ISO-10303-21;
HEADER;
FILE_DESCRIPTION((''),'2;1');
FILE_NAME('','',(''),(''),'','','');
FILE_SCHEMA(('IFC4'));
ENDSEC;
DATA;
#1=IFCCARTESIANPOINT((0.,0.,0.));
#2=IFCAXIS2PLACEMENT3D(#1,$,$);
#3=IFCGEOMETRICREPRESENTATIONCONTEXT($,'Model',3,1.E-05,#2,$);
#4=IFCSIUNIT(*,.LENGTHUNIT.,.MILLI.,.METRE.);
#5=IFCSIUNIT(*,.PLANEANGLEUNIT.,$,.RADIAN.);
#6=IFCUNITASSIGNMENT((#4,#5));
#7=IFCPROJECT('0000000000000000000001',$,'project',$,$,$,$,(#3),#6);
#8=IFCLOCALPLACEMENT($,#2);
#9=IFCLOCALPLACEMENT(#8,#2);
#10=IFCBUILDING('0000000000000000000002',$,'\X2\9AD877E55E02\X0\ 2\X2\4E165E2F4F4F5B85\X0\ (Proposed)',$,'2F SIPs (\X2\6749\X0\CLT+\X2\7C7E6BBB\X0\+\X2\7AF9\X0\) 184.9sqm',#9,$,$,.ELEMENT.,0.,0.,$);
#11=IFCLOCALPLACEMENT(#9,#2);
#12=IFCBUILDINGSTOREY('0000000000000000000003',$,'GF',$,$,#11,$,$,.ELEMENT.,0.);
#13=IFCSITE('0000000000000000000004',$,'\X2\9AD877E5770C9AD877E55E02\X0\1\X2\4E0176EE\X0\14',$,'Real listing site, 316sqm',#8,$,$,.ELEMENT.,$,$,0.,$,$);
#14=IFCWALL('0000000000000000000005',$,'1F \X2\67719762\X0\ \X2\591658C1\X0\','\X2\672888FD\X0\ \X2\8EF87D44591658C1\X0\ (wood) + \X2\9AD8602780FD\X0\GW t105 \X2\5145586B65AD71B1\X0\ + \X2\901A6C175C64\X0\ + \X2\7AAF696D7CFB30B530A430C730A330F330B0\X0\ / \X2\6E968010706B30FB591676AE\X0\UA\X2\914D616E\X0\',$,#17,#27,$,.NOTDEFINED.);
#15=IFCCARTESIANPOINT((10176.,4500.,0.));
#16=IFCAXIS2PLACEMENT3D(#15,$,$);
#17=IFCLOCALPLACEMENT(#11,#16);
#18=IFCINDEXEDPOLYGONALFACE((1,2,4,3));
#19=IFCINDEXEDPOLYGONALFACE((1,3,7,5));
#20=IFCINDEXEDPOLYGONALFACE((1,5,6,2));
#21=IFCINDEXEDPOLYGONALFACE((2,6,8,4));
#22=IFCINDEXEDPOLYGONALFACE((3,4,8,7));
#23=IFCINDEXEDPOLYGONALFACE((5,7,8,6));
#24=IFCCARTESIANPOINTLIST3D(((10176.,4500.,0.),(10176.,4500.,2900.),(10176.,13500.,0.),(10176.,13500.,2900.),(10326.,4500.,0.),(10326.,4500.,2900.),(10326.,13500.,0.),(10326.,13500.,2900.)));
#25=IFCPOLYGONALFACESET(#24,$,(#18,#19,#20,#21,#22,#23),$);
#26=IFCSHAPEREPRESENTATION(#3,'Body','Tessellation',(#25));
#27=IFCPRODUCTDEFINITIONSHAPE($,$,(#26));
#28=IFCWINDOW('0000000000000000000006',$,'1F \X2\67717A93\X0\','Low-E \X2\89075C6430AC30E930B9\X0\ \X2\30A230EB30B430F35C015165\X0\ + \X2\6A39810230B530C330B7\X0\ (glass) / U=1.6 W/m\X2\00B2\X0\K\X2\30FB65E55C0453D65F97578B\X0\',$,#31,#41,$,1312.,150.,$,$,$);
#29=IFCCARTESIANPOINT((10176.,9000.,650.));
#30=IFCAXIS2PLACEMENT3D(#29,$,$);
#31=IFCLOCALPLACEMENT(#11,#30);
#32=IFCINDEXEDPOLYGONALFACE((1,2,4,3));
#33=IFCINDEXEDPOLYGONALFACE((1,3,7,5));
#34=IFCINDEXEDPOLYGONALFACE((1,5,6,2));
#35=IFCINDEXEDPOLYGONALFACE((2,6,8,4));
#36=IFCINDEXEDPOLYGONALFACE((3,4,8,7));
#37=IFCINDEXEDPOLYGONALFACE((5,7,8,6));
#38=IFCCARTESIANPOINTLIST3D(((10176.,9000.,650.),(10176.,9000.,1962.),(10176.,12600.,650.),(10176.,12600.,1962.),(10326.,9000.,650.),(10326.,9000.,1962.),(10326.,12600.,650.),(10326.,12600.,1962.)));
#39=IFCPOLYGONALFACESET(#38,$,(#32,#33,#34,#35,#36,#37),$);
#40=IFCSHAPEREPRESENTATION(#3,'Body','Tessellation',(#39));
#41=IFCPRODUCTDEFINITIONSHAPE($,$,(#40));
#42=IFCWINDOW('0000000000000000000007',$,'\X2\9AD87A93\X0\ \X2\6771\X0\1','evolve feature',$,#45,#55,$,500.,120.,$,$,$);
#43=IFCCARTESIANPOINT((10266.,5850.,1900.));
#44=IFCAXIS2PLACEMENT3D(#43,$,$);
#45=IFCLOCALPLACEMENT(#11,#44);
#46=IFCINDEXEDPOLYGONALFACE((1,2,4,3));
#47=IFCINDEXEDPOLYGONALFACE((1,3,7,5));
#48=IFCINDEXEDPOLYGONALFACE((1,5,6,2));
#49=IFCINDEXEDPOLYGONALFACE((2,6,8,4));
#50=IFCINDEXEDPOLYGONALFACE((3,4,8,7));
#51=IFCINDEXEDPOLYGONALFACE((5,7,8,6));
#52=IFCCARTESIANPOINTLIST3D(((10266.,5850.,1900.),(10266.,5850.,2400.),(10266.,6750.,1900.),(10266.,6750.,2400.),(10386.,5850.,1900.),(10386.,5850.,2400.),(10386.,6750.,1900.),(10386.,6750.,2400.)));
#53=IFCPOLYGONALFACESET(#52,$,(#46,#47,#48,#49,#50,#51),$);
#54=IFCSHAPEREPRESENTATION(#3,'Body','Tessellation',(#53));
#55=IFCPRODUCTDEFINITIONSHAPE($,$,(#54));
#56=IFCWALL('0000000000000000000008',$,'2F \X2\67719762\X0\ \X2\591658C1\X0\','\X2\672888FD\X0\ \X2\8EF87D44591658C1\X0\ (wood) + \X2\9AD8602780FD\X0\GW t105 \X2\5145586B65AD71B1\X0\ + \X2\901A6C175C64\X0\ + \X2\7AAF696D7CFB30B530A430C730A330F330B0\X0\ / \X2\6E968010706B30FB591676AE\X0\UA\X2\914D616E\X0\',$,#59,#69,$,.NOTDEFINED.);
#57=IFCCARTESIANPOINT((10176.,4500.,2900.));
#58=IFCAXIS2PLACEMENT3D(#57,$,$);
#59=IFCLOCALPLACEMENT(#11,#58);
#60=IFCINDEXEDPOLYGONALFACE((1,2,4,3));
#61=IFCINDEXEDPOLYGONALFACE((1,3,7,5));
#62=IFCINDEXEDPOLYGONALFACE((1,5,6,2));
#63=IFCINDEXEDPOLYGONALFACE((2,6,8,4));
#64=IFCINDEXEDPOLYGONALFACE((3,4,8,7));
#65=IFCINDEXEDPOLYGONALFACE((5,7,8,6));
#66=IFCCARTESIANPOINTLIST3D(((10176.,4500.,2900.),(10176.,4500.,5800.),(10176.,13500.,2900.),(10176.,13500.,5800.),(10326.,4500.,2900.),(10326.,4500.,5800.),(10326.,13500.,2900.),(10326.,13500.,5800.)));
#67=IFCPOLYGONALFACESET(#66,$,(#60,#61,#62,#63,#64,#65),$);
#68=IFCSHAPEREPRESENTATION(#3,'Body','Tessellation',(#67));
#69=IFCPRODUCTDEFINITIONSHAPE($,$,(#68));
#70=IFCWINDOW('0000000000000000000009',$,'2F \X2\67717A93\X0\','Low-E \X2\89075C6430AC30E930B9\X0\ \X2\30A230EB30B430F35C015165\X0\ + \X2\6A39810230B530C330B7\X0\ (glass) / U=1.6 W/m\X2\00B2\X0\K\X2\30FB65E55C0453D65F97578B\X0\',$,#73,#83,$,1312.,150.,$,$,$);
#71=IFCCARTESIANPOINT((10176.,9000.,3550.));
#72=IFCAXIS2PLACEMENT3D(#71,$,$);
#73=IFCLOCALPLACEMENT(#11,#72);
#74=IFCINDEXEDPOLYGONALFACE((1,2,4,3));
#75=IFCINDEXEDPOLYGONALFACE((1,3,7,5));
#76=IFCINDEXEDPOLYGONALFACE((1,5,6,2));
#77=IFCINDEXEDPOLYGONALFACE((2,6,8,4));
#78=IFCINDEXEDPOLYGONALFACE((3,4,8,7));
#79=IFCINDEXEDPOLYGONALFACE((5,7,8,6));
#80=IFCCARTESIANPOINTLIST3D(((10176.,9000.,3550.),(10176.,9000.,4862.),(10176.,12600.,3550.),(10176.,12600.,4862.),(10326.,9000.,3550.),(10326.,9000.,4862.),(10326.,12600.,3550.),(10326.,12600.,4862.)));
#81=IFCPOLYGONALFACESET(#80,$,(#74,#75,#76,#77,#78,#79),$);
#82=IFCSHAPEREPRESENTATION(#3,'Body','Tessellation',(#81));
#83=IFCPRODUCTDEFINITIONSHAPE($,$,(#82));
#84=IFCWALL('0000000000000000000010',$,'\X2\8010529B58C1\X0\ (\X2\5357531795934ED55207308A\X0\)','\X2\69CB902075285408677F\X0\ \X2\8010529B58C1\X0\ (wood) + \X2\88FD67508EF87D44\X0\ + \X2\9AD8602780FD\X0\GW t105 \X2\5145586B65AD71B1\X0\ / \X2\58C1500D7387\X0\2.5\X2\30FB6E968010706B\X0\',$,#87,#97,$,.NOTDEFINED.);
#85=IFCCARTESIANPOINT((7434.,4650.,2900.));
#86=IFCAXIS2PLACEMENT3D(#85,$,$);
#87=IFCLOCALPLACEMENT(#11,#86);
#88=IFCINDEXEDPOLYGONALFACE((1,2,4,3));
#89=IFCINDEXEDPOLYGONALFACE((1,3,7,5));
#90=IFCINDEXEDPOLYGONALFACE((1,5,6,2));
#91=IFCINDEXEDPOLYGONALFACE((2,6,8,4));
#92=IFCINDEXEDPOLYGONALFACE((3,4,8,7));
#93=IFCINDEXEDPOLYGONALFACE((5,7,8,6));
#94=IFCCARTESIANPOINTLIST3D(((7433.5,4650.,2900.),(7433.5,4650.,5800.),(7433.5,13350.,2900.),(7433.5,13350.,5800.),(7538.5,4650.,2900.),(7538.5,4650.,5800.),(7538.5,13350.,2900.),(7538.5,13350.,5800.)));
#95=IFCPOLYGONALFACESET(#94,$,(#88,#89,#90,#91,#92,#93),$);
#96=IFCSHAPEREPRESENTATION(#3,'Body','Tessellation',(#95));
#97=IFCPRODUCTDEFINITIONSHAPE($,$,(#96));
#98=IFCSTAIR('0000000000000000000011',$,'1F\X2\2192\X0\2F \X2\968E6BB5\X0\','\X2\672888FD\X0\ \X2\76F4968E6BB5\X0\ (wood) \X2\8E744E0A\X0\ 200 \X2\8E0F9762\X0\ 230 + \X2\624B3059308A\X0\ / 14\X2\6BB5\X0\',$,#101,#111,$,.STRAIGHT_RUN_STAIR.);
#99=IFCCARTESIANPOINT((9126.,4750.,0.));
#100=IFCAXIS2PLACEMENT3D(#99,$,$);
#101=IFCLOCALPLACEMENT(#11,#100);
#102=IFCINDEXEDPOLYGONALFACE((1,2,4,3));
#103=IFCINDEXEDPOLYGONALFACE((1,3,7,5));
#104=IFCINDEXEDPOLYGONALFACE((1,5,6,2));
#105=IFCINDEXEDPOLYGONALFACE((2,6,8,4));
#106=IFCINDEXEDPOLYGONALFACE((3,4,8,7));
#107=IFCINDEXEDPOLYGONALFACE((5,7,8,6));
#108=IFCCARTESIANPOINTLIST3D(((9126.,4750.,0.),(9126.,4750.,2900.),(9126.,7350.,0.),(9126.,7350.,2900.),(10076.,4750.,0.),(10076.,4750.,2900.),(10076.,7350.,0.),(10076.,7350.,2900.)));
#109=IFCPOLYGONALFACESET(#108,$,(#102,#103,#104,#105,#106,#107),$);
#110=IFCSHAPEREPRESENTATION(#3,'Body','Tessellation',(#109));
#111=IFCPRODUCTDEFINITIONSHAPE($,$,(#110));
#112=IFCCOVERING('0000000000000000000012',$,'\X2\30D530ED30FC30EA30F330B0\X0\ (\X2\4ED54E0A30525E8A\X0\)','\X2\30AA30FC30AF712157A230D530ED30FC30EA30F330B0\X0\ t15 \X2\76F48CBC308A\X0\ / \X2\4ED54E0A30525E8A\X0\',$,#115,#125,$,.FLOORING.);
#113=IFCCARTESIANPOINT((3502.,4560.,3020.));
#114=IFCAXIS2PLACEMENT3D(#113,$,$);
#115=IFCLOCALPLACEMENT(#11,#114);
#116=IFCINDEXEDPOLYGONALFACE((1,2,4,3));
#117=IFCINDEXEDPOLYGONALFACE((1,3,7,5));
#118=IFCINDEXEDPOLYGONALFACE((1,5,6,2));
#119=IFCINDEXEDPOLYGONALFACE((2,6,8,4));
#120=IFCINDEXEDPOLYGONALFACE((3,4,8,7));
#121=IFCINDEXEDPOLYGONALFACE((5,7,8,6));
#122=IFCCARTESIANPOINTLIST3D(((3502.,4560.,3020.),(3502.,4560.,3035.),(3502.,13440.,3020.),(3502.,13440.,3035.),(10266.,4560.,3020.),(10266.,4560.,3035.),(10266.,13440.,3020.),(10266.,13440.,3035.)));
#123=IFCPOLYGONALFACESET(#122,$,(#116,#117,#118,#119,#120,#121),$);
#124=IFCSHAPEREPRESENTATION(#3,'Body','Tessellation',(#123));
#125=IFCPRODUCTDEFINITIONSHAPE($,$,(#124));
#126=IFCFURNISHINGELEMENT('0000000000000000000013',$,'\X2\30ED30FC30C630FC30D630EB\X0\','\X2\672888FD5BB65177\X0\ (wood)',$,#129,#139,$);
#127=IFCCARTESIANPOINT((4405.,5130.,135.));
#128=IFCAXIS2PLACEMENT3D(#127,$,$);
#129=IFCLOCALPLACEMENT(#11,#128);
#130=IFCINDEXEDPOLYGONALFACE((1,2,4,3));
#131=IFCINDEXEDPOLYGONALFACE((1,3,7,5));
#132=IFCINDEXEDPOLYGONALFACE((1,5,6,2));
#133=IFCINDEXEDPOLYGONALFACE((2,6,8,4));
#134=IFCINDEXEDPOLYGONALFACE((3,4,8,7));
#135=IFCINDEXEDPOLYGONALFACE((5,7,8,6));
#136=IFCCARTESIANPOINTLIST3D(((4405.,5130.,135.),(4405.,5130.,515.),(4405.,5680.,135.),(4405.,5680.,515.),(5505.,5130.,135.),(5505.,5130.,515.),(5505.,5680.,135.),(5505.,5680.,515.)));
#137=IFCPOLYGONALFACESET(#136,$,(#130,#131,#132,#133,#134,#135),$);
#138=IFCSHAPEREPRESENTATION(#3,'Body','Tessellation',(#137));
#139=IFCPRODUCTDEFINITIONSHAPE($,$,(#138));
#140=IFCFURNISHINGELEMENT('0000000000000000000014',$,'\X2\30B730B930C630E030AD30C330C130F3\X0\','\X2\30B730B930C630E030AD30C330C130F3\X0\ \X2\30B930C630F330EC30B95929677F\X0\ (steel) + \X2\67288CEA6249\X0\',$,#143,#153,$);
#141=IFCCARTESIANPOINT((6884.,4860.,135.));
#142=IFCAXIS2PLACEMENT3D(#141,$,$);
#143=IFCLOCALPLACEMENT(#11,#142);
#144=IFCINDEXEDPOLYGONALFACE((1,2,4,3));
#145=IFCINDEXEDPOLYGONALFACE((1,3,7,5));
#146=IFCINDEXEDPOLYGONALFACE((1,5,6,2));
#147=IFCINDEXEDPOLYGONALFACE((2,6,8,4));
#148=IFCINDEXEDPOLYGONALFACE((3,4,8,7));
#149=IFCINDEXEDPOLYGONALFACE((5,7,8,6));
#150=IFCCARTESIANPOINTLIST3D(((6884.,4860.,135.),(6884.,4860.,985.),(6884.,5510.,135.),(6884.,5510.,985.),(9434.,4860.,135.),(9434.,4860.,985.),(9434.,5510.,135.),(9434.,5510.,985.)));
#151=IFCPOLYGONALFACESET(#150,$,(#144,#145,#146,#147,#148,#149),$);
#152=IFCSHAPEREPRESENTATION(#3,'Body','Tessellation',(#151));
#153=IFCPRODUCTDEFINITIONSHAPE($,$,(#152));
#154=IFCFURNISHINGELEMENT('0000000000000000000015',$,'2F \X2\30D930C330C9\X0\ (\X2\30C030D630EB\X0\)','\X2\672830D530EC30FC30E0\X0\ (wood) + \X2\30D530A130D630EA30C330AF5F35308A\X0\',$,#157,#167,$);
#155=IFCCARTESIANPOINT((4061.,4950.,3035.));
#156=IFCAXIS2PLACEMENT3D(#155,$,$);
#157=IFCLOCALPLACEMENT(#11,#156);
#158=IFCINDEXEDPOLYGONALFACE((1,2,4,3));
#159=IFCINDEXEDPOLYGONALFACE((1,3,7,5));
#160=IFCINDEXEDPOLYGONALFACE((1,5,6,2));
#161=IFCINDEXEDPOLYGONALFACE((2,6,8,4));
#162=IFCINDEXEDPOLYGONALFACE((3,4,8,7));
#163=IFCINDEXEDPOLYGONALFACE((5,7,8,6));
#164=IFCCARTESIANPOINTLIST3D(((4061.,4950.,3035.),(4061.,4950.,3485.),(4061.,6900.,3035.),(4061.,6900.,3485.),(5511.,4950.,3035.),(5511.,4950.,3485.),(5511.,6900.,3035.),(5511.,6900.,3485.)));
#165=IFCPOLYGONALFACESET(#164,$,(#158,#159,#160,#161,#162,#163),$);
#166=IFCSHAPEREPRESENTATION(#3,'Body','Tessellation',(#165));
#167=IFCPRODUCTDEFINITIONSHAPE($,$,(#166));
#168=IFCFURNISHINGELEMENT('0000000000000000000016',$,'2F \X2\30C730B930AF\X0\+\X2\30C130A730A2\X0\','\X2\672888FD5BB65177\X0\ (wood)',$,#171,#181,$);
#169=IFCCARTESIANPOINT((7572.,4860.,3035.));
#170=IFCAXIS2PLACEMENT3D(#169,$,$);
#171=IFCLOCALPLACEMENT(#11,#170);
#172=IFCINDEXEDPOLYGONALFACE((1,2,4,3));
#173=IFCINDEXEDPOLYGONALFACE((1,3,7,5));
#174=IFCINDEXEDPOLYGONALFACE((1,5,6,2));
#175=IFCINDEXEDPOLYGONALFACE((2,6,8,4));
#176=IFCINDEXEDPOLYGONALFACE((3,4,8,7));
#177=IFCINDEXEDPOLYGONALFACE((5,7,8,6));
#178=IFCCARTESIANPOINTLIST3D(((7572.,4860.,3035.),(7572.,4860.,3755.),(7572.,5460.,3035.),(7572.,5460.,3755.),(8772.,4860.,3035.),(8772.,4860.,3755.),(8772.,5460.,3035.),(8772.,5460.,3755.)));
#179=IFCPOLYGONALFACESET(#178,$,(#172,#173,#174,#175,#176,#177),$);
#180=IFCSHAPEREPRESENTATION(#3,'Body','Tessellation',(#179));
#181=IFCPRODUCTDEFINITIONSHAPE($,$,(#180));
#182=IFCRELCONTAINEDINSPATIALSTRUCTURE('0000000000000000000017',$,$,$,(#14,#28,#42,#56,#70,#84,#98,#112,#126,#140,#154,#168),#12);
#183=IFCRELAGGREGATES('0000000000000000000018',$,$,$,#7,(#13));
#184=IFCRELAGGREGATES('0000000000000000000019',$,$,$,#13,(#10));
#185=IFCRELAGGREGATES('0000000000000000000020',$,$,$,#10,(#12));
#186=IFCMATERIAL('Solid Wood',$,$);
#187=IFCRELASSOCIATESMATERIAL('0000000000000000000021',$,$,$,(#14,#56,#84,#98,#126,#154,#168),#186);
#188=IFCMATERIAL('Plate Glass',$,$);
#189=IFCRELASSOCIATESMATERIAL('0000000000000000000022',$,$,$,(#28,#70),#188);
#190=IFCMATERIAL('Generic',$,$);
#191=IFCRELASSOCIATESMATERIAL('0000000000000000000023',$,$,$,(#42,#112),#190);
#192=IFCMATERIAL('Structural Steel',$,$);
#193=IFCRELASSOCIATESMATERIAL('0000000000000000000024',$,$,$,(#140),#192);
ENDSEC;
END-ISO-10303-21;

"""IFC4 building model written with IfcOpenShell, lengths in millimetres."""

from ifc_helpers import new_model, si_unit, frame, frame_2d, origin, place, context, project, spatial, rectangle, extrude, material, element, fill, save


model = new_model("IFC4")

# Units and contexts
model_context = context("Model", 3, precision=1e-05, world=origin())
ifc_project = project(units=[si_unit("LENGTHUNIT", "METRE", prefix="MILLI"), si_unit("PLANEANGLEUNIT", "RADIAN")], contexts=[model_context])

# Site, building, storey
site_placement = place(None, origin())
site = spatial("IfcSite", under=ifc_project, at=site_placement, Name="高知県高知市1丁目14", ObjectType="Real listing site, 316sqm", CompositionType="ELEMENT", RefElevation=0.0)
building_placement = place(site_placement, origin())
building = spatial("IfcBuilding", under=site, at=building_placement, Name="高知市 2世帯住宅 (Proposed)", ObjectType="2F SIPs (杉CLT+籾殻+竹) 184.9sqm", CompositionType="ELEMENT", ElevationOfRefHeight=0.0, ElevationOfTerrain=0.0)
storey_placement = place(building_placement, origin())
storey = spatial("IfcBuildingStorey", under=building, at=storey_placement, Name="GF", CompositionType="ELEMENT", Elevation=0.0)

# Shared definitions
ifc_material_1 = material(Name="Solid Wood")

# Wall, openings, windows
wall_1_placement = place(storey_placement, frame((10176.0, 4500.0, 0.0)))
wall_1 = element("IfcWall", 1, at=wall_1_placement, inside=storey, material=ifc_material_1, Name="1F 東面 外壁", Description="木製 軸組外壁 (wood) + 高性能GW t105 充填断熱 + 通気層 + 窯業系サイディング / 準耐火・外皮UA配慮", PredefinedType="NOTDEFINED", context=model_context, shape_type="SweptSolid", body=[
    extrude(rectangle(XDim=150.0, YDim=9000.0, at=frame_2d((75.0, 4500.0))), frame((10176.0, 4500.0, 0.0)), (0.0, 0.0, 1.0), 2900.0),
])
opening_1_placement = place(storey_placement, frame((10176.0, 9000.0, 650.0)))
opening_1 = element("IfcOpeningElement", 2, at=opening_1_placement, cuts=wall_1, PredefinedType="NOTDEFINED", context=model_context, shape_type="SweptSolid", body=[
    extrude(rectangle(XDim=150.0, YDim=3600.0, at=frame_2d((75.0, 1800.0))), frame((10176.0, 9000.0, 650.0)), (0.0, 0.0, 1.0), 1312.0),
])
opening_2_placement = place(storey_placement, frame((10266.0, 5850.0, 1900.0)))
opening_2 = element("IfcOpeningElement", 3, at=opening_2_placement, cuts=wall_1, PredefinedType="NOTDEFINED", context=model_context, shape_type="SweptSolid", body=[
    extrude(rectangle(XDim=120.0, YDim=900.0, at=frame_2d((60.0, 450.0))), frame((10266.0, 5850.0, 1900.0)), (0.0, 0.0, 1.0), 500.0),
])
ifc_material_2 = material(Name="Plate Glass")
window_1_placement = place(storey_placement, frame((10176.0, 9000.0, 650.0)))
window_1 = element("IfcWindow", 4, at=window_1_placement, inside=storey, material=ifc_material_2, Name="1F 東窓", Description="Low-E 複層ガラス アルゴン封入 + 樹脂サッシ (glass) / U=1.6 W/m²K・日射取得型", OverallHeight=1312.0, OverallWidth=150.0, context=model_context, shape_type="SweptSolid", body=[
    extrude(rectangle(XDim=150.0, YDim=3600.0, at=frame_2d((75.0, 1800.0))), frame((10176.0, 9000.0, 650.0)), (0.0, 0.0, 1.0), 1312.0),
])
fill(opening_1, window_1)
ifc_material_3 = material(Name="Generic")
window_2_placement = place(storey_placement, frame((10266.0, 5850.0, 1900.0)))
window_2 = element("IfcWindow", 5, at=window_2_placement, inside=storey, material=ifc_material_3, Name="高窓 東1", Description="evolve feature", OverallHeight=500.0, OverallWidth=120.0, context=model_context, shape_type="SweptSolid", body=[
    extrude(rectangle(XDim=120.0, YDim=900.0, at=frame_2d((60.0, 450.0))), frame((10266.0, 5850.0, 1900.0)), (0.0, 0.0, 1.0), 500.0),
])
fill(opening_2, window_2)

# Wall, opening, window
wall_2_placement = place(storey_placement, frame((10176.0, 4500.0, 2900.0)))
wall_2 = element("IfcWall", 6, at=wall_2_placement, inside=storey, material=ifc_material_1, Name="2F 東面 外壁", Description="木製 軸組外壁 (wood) + 高性能GW t105 充填断熱 + 通気層 + 窯業系サイディング / 準耐火・外皮UA配慮", PredefinedType="NOTDEFINED", context=model_context, shape_type="SweptSolid", body=[
    extrude(rectangle(XDim=150.0, YDim=9000.0, at=frame_2d((75.0, 4500.0))), frame((10176.0, 4500.0, 2900.0)), (0.0, 0.0, 1.0), 2900.0),
])
opening_3_placement = place(storey_placement, frame((10176.0, 9000.0, 3550.0)))
opening_3 = element("IfcOpeningElement", 7, at=opening_3_placement, cuts=wall_2, PredefinedType="NOTDEFINED", context=model_context, shape_type="SweptSolid", body=[
    extrude(rectangle(XDim=150.0, YDim=3600.0, at=frame_2d((75.0, 1800.0))), frame((10176.0, 9000.0, 3550.0)), (0.0, 0.0, 1.0), 1312.0),
])
window_3_placement = place(storey_placement, frame((10176.0, 9000.0, 3550.0)))
window_3 = element("IfcWindow", 8, at=window_3_placement, inside=storey, material=ifc_material_2, Name="2F 東窓", Description="Low-E 複層ガラス アルゴン封入 + 樹脂サッシ (glass) / U=1.6 W/m²K・日射取得型", OverallHeight=1312.0, OverallWidth=150.0, context=model_context, shape_type="SweptSolid", body=[
    extrude(rectangle(XDim=150.0, YDim=3600.0, at=frame_2d((75.0, 1800.0))), frame((10176.0, 9000.0, 3550.0)), (0.0, 0.0, 1.0), 1312.0),
])
fill(opening_3, window_3)

# Wall
wall_3_placement = place(storey_placement, frame((7434.0, 4650.0, 2900.0)))
element("IfcWall", 9, at=wall_3_placement, inside=storey, material=ifc_material_1, Name="耐力壁 (南北間仕切り)", Description="構造用合板 耐力壁 (wood) + 製材軸組 + 高性能GW t105 充填断熱 / 壁倍率2.5・準耐火", PredefinedType="NOTDEFINED", context=model_context, shape_type="SweptSolid", body=[
    extrude(rectangle(XDim=105.0, YDim=8700.0, at=frame_2d((52.0, 4350.0))), frame((7434.0, 4650.0, 2900.0)), (0.0, 0.0, 1.0), 2900.0),
])

# Stair
stair_placement = place(storey_placement, frame((9126.0, 4750.0, 0.0)))
element("IfcStair", 10, at=stair_placement, inside=storey, material=ifc_material_1, Name="1F→2F 階段", Description="木製 直階段 (wood) 蹴上 200 踏面 230 + 手すり / 14段", PredefinedType="STRAIGHT_RUN_STAIR", context=model_context, shape_type="SweptSolid", body=[
    extrude(rectangle(XDim=950.0, YDim=2600.0, at=frame_2d((475.0, 1300.0))), frame((9126.0, 4750.0, 0.0)), (0.0, 0.0, 1.0), 2900.0),
])

# Covering
covering_placement = place(storey_placement, frame((3502.0, 4560.0, 3020.0)))
element("IfcCovering", 11, at=covering_placement, inside=storey, material=ifc_material_3, Name="フローリング (仕上げ床)", Description="オーク無垢フローリング t15 直貼り / 仕上げ床", PredefinedType="FLOORING", context=model_context, shape_type="SweptSolid", body=[
    extrude(rectangle(XDim=6764.0, YDim=8880.0, at=frame_2d((3382.0, 4440.0))), frame((3502.0, 4560.0, 3020.0)), (0.0, 0.0, 1.0), 15.0),
])

# Furnishing elements
furnishing_1_placement = place(storey_placement, frame((4405.0, 5130.0, 135.0)))
element("IfcFurnishingElement", 12, at=furnishing_1_placement, inside=storey, material=ifc_material_1, Name="ローテーブル", Description="木製家具 (wood)", context=model_context, shape_type="SweptSolid", body=[
    extrude(rectangle(XDim=1100.0, YDim=550.0, at=frame_2d((550.0, 275.0))), frame((4405.0, 5130.0, 135.0)), (0.0, 0.0, 1.0), 380.0),
])
ifc_material_4 = material(Name="Structural Steel")
furnishing_2_placement = place(storey_placement, frame((6884.0, 4860.0, 135.0)))
element("IfcFurnishingElement", 13, at=furnishing_2_placement, inside=storey, material=ifc_material_4, Name="システムキッチン", Description="システムキッチン ステンレス天板 (steel) + 木質扉", context=model_context, shape_type="SweptSolid", body=[
    extrude(rectangle(XDim=2550.0, YDim=650.0, at=frame_2d((1275.0, 325.0))), frame((6884.0, 4860.0, 135.0)), (0.0, 0.0, 1.0), 850.0),
])
furnishing_3_placement = place(storey_placement, frame((4061.0, 4950.0, 3035.0)))
element("IfcFurnishingElement", 14, at=furnishing_3_placement, inside=storey, material=ifc_material_1, Name="2F ベッド (ダブル)", Description="木フレーム (wood) + ファブリック張り", context=model_context, shape_type="SweptSolid", body=[
    extrude(rectangle(XDim=1450.0, YDim=1950.0, at=frame_2d((725.0, 975.0))), frame((4061.0, 4950.0, 3035.0)), (0.0, 0.0, 1.0), 450.0),
])
furnishing_4_placement = place(storey_placement, frame((7572.0, 4860.0, 3035.0)))
element("IfcFurnishingElement", 15, at=furnishing_4_placement, inside=storey, material=ifc_material_1, Name="2F デスク+チェア", Description="木製家具 (wood)", context=model_context, shape_type="SweptSolid", body=[
    extrude(rectangle(XDim=1200.0, YDim=600.0, at=frame_2d((600.0, 300.0))), frame((7572.0, 4860.0, 3035.0)), (0.0, 0.0, 1.0), 720.0),
])

save(model, "model.ifc")
